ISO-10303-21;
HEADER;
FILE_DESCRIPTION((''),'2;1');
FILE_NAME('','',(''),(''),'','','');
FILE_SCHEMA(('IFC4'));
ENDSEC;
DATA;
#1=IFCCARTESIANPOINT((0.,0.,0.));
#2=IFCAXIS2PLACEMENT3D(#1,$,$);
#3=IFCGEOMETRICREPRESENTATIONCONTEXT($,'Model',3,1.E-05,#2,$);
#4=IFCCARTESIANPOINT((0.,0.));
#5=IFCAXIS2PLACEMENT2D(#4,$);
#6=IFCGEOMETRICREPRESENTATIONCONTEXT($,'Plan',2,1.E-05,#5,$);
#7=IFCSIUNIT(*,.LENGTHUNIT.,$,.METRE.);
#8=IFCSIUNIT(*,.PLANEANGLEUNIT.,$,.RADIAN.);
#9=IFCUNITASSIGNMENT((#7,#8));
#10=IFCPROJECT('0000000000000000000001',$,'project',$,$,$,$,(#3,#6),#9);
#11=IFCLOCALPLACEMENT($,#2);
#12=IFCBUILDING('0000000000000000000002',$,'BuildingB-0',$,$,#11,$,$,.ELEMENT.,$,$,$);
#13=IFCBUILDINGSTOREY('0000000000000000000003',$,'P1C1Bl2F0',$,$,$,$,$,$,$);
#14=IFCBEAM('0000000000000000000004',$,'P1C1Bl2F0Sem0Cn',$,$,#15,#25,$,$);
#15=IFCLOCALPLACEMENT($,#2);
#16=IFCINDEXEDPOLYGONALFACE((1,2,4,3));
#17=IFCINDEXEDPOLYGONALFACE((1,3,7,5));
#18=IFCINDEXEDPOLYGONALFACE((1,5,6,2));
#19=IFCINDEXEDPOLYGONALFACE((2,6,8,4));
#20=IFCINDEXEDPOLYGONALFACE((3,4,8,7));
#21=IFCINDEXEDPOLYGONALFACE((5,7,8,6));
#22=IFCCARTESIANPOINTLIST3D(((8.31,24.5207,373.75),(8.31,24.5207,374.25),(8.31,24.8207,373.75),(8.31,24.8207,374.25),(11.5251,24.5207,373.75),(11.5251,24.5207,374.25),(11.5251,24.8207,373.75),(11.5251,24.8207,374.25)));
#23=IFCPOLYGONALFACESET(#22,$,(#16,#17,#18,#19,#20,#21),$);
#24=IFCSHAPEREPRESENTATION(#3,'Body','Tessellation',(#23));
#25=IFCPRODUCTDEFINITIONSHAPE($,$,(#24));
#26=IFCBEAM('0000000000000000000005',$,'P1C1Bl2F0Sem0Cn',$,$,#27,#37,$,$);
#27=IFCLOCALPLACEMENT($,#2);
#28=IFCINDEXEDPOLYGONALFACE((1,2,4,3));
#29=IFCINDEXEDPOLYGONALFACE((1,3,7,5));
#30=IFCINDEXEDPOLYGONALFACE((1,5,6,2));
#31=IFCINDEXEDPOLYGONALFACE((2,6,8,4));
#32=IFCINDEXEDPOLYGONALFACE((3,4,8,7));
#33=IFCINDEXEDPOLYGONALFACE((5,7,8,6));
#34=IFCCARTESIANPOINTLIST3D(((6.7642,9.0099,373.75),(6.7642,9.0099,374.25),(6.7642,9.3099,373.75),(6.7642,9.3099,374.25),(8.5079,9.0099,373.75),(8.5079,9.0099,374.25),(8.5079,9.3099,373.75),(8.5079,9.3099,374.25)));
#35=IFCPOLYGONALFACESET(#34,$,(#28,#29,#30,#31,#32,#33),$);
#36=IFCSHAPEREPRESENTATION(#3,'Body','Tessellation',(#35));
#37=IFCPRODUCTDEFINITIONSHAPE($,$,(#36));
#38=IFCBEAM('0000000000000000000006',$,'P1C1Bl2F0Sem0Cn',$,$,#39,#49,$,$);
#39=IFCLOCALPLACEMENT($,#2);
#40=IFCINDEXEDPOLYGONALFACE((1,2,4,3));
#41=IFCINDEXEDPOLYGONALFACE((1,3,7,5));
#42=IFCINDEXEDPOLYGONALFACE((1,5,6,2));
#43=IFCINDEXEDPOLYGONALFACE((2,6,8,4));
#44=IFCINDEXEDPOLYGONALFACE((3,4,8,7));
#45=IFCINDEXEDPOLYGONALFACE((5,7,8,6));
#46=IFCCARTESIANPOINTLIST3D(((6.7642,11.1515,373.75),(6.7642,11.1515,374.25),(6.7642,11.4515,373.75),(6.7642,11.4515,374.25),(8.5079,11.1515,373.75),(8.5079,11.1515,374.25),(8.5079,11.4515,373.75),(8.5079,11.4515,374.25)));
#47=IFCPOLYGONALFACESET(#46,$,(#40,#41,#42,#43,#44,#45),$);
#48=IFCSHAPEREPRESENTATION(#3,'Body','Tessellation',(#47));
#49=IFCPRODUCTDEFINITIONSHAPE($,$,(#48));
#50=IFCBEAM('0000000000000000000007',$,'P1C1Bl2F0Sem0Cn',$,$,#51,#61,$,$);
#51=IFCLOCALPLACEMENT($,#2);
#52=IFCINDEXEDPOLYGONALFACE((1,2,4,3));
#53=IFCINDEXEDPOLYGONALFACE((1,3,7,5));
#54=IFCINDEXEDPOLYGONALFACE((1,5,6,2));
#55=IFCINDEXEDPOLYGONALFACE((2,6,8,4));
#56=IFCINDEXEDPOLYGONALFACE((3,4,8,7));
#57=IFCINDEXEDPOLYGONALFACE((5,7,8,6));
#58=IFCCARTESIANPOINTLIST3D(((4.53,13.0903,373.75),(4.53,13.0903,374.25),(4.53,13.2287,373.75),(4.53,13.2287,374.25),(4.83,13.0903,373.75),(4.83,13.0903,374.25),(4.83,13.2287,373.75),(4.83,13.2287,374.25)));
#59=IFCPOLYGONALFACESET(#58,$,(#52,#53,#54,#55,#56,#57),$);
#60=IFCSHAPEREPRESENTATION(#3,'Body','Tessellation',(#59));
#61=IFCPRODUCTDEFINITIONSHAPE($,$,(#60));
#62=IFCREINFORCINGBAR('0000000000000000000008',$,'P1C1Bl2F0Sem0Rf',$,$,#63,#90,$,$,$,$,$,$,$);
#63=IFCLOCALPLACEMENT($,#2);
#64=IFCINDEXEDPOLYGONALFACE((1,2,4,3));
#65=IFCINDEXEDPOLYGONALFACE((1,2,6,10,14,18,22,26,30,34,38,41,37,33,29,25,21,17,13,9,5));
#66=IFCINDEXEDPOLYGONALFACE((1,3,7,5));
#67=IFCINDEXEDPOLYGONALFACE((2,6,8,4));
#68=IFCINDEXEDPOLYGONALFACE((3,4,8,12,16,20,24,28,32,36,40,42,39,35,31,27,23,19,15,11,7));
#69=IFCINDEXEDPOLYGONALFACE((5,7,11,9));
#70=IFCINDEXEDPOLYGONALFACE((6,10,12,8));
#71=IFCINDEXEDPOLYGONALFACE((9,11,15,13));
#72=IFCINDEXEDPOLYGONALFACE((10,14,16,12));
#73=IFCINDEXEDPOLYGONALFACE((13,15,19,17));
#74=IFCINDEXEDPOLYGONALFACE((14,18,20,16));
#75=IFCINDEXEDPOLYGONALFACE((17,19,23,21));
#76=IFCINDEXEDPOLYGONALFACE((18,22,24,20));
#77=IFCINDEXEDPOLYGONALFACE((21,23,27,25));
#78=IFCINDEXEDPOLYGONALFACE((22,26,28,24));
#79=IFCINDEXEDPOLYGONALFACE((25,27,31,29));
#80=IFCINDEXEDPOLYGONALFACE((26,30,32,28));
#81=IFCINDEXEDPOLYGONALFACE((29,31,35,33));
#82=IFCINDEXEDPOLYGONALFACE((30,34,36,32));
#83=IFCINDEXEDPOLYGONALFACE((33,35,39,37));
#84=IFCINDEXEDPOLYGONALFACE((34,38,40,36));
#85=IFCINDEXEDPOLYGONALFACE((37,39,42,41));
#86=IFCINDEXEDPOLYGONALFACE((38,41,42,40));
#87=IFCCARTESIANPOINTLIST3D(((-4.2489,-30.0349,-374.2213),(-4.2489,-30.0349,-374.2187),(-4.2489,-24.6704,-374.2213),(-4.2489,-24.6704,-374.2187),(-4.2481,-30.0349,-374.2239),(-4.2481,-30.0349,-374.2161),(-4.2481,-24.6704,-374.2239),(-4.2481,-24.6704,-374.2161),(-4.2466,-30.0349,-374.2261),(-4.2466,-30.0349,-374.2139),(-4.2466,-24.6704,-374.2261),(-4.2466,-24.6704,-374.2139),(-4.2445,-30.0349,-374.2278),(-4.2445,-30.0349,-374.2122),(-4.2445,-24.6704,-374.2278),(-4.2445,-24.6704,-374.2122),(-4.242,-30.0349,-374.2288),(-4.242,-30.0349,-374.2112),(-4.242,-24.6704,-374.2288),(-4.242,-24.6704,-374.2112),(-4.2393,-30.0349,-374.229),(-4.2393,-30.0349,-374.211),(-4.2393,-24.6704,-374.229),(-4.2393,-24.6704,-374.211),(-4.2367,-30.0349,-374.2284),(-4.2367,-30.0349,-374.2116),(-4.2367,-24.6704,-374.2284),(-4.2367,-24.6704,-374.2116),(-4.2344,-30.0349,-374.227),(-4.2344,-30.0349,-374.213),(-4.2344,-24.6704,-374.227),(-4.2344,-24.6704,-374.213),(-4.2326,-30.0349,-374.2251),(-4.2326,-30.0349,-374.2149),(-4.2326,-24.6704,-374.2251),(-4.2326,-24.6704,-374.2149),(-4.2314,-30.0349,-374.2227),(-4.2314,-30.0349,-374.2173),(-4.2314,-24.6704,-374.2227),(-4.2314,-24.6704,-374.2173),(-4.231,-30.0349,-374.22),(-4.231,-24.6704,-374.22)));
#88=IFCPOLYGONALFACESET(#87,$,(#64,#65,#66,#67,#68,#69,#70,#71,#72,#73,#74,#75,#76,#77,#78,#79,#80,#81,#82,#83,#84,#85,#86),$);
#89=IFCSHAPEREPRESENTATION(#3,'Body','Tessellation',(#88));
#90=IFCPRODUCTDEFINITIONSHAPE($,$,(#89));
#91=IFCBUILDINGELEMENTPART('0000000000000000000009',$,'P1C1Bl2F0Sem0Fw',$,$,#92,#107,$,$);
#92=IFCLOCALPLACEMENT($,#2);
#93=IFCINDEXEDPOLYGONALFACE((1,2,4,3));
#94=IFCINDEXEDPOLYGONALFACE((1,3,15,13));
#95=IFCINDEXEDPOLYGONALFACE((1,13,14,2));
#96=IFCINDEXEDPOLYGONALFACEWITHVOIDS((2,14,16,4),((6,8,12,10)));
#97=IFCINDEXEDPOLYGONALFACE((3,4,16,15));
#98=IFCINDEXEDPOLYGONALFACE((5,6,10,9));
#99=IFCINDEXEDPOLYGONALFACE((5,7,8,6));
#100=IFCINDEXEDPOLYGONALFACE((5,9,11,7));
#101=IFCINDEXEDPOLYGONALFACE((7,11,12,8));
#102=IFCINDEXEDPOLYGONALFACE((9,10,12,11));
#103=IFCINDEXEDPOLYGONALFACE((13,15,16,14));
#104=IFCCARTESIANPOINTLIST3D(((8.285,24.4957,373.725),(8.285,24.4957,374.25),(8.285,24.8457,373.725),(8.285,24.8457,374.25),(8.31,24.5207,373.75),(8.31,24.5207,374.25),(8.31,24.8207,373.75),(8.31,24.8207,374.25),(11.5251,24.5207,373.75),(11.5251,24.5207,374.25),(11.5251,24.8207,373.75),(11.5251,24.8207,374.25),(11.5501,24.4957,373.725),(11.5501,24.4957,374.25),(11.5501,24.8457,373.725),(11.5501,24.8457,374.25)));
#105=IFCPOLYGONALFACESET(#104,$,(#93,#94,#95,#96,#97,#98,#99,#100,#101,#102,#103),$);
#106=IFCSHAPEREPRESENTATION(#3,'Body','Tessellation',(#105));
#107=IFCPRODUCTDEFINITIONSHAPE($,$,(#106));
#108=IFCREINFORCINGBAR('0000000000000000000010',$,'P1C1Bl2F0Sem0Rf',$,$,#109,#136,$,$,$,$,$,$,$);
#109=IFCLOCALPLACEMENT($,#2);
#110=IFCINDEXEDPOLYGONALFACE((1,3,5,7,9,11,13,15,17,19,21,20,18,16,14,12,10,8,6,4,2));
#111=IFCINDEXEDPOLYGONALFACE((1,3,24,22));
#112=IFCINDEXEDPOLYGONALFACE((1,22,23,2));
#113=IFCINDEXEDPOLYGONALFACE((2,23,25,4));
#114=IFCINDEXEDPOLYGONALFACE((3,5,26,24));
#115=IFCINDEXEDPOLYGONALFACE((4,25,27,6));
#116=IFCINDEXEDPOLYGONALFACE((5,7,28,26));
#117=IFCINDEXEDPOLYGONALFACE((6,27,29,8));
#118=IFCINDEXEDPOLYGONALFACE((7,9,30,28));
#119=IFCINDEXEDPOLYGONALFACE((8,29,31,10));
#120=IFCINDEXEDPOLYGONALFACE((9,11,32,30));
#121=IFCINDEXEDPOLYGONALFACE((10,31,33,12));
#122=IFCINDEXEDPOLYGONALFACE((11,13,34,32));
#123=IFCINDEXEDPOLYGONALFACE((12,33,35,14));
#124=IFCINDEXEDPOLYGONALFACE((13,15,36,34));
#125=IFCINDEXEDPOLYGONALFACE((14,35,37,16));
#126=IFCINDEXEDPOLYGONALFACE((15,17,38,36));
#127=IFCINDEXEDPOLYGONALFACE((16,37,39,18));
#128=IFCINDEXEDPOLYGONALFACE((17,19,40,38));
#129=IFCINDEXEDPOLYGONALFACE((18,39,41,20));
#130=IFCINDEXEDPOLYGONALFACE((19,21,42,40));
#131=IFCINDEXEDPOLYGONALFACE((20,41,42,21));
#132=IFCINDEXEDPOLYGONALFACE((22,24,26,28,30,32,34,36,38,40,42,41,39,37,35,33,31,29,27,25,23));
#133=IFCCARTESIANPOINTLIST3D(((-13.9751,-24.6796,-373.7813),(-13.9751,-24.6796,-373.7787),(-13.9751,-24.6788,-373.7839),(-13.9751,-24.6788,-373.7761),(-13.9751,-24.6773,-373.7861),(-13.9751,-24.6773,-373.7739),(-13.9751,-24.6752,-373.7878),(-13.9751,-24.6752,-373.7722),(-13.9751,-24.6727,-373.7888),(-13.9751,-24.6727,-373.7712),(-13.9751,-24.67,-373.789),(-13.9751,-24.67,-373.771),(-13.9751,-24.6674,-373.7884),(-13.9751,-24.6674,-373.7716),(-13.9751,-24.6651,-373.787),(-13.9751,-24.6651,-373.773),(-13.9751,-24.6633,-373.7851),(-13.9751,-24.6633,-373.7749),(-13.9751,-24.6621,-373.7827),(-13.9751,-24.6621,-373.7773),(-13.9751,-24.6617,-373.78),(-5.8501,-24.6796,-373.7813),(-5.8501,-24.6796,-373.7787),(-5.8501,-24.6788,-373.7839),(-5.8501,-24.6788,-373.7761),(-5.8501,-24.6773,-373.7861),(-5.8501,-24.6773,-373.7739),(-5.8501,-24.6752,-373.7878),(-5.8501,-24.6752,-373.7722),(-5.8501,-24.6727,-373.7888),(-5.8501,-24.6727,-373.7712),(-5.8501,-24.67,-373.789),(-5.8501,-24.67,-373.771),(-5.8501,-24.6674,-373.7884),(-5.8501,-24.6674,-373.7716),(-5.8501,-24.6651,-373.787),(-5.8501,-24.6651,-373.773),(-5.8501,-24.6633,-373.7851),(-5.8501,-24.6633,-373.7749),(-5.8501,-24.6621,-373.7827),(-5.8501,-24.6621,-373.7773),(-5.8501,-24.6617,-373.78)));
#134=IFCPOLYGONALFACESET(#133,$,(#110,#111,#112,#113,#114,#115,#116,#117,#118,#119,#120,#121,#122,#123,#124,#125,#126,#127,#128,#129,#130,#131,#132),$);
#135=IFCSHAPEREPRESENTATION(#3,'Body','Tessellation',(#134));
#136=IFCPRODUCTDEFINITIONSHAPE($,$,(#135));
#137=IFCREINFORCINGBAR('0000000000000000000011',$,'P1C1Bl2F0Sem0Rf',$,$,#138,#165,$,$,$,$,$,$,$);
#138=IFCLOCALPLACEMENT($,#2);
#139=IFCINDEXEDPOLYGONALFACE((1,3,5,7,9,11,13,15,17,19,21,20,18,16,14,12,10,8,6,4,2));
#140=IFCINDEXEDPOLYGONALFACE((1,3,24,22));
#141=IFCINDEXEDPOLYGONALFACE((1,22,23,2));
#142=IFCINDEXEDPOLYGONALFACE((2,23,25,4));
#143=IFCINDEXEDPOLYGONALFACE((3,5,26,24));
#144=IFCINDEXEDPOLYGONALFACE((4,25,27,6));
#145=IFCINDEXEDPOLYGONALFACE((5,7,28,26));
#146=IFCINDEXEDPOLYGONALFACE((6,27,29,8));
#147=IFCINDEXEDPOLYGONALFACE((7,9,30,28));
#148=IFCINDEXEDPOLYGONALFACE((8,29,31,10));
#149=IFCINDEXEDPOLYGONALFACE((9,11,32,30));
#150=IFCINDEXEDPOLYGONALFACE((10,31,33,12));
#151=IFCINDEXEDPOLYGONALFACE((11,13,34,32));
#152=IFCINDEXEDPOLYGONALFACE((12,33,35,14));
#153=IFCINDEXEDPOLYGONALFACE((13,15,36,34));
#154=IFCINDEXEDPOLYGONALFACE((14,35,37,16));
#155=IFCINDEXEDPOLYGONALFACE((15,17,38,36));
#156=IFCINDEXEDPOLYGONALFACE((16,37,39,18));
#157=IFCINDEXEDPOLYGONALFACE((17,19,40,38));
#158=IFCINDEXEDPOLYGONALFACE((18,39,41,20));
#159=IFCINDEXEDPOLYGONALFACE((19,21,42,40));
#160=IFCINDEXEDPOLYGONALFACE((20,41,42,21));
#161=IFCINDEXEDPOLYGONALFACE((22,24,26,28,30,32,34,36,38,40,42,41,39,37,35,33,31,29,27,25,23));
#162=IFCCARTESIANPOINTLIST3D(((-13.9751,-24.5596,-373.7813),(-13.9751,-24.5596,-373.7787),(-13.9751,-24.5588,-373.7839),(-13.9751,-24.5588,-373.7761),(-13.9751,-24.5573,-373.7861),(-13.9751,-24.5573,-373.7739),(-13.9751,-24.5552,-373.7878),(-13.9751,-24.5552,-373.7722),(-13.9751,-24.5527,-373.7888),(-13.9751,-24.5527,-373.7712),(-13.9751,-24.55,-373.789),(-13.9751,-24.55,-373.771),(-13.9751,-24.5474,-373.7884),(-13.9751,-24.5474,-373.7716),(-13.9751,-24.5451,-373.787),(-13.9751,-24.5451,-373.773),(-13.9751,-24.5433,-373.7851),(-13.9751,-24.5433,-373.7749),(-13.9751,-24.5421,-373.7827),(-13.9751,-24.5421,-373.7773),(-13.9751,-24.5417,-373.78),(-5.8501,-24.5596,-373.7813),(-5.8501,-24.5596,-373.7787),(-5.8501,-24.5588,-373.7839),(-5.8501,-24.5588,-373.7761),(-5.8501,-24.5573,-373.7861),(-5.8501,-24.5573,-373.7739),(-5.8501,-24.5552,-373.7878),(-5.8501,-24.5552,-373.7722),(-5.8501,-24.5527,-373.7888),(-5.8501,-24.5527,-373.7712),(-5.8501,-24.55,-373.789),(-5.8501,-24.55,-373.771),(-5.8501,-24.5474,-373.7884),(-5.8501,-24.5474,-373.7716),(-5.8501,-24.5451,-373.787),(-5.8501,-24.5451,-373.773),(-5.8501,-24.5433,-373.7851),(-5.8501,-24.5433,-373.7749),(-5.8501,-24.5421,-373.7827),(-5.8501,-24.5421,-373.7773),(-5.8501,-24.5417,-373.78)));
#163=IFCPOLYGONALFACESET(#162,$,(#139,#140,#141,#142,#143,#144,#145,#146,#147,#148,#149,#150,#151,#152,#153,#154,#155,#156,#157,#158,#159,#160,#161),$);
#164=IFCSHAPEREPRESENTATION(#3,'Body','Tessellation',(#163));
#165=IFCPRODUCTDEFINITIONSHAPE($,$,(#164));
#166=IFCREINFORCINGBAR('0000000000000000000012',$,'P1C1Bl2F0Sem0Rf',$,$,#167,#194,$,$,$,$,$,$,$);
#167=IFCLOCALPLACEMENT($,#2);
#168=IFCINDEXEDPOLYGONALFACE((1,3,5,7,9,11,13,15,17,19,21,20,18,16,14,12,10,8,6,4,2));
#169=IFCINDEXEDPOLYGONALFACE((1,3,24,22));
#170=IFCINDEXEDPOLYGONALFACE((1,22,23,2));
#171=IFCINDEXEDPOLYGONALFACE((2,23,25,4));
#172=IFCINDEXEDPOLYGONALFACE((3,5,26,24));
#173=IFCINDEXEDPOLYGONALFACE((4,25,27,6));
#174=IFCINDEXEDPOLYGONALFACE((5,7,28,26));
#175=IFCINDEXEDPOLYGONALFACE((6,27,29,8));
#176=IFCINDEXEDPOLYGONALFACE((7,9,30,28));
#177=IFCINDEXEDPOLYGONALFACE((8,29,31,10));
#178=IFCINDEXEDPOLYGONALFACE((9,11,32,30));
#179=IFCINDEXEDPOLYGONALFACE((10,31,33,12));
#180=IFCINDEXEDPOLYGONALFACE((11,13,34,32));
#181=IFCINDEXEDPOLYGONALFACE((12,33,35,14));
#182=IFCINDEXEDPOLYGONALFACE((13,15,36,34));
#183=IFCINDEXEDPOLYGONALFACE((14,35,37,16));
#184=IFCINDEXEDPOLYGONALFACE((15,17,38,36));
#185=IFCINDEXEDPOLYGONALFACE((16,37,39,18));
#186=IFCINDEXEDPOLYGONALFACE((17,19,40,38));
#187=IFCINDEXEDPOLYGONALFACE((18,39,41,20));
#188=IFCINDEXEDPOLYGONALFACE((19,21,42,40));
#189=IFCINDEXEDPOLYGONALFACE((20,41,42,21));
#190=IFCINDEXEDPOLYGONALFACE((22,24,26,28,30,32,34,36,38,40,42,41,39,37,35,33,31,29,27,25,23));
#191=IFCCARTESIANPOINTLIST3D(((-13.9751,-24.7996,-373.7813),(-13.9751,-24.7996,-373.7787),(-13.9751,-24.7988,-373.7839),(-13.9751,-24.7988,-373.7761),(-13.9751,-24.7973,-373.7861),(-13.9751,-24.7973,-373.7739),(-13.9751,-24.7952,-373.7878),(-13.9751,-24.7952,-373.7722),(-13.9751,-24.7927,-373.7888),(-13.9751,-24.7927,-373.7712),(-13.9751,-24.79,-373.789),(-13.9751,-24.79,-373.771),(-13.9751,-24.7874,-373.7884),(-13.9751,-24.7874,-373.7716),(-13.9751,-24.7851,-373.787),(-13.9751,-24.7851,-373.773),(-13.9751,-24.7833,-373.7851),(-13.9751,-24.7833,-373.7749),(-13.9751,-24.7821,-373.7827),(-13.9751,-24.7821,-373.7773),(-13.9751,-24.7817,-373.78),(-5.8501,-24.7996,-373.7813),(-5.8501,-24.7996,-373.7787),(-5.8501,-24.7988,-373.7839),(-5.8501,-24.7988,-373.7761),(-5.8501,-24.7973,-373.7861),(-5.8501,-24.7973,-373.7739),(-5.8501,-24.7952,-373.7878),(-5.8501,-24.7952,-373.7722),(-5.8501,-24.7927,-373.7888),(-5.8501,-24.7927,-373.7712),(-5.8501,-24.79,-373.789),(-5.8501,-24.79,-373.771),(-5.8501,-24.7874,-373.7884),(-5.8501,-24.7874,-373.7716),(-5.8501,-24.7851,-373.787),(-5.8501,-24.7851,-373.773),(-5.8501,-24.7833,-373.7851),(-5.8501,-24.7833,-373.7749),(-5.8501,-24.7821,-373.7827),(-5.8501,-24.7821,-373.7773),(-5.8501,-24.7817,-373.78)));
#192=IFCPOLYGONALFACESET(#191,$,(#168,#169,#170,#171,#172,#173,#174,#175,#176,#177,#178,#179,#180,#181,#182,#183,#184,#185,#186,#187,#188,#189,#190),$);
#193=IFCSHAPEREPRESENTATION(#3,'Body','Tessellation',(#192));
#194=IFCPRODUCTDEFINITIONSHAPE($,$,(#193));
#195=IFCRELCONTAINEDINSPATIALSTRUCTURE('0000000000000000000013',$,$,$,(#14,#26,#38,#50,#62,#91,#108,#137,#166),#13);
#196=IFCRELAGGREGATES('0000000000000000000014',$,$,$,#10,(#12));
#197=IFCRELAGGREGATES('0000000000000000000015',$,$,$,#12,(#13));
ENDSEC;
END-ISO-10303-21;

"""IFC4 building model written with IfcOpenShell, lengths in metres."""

from ifc_helpers import new_model, entity, si_unit, origin, origin_2d, place, context, project, spatial, polyline, outline, extrude, element, save


model = new_model("IFC4")

# Units and contexts
model_context = context("Model", 3, precision=1e-05, world=origin())
plan_context = context("Plan", 2, precision=1e-05, world=origin_2d())
ifc_project = project(units=[si_unit("LENGTHUNIT", "METRE"), si_unit("PLANEANGLEUNIT", "RADIAN")], contexts=[model_context, plan_context])

# Building, storey
building_placement = place(None, origin())
building = spatial("IfcBuilding", under=ifc_project, at=building_placement, Name="BuildingB-0", CompositionType="ELEMENT")
storey = spatial("IfcBuildingStorey", under=building, Name="P1C1Bl2F0")

# Beams
element("IfcBeam", 1, inside=storey, Name="P1C1Bl2F0Sem0Cn", context=model_context, shape_type="SweptSolid", body=[
    extrude(outline(polyline([(8.31, 24.5207, 373.75), (8.31, 24.8207, 373.75), (11.5251, 24.8207, 373.75), (11.5251, 24.5207, 373.75), (8.31, 24.5207, 373.75)])), None, (0.0, 0.0, 1.0), 0.5),
])
element("IfcBeam", 2, inside=storey, Name="P1C1Bl2F0Sem0Cn", context=model_context, shape_type="SweptSolid", body=[
    extrude(outline(polyline([(6.7642, 9.0099, 373.75), (6.7642, 9.3099, 373.75), (8.5079, 9.3099, 373.75), (8.5079, 9.0099, 373.75), (6.7642, 9.0099, 373.75)])), None, (0.0, 0.0, 1.0), 0.5),
])
element("IfcBeam", 3, inside=storey, Name="P1C1Bl2F0Sem0Cn", context=model_context, shape_type="SweptSolid", body=[
    extrude(outline(polyline([(6.7642, 11.1515, 373.75), (6.7642, 11.4515, 373.75), (8.5079, 11.4515, 373.75), (8.5079, 11.1515, 373.75), (6.7642, 11.1515, 373.75)])), None, (0.0, 0.0, 1.0), 0.5),
])
element("IfcBeam", 4, inside=storey, Name="P1C1Bl2F0Sem0Cn", context=model_context, shape_type="SweptSolid", body=[
    extrude(outline(polyline([(4.53, 13.0903, 373.75), (4.53, 13.2287, 373.75), (4.83, 13.2287, 373.75), (4.83, 13.0903, 373.75), (4.53, 13.0903, 373.75)])), None, (0.0, 0.0, 1.0), 0.5),
])

# Reinforcing bar
element("IfcReinforcingBar", 5, inside=storey, Name="P1C1Bl2F0Sem0Rf", context=model_context, shape_type="SweptSolid", body=[
    entity("IfcSurfaceCurveSweptAreaSolid", entity("IfcCircleProfileDef", "AREA", None, None, 0.009), None, entity("IfcPolyline", [entity("IfcCartesianPoint", [4.24, 24.6704, 374.22]), entity("IfcCartesianPoint", [4.24, 30.0349, 374.22])]), None, None, entity("IfcPlane", entity("IfcAxis2Placement3D", entity("IfcCartesianPoint", [4.24, 24.6704, 374.22]), entity("IfcDirection", [0.0, 0.0, 1.0]), entity("IfcDirection", [1.0, 0.0, 0.0])))),
])

# Building element part, opening
building_element_part_1 = element("IfcBuildingElementPart", 6, inside=storey, Name="P1C1Bl2F0Sem0Fw", context=model_context, shape_type="SweptSolid", body=[
    extrude(outline(polyline([(8.285, 24.4957, 373.725), (8.285, 24.8457, 373.725), (11.5501, 24.8457, 373.725), (11.5501, 24.4957, 373.725), (8.285, 24.4957, 373.725)])), None, (0.0, 0.0, 1.0), 0.525),
])
element("IfcOpeningElement", 7, inside=storey, cuts=building_element_part_1, context=model_context, shape_type="SweptSolid", body=[
    extrude(outline(polyline([(8.31, 24.5207, 373.75), (8.31, 24.8207, 373.75), (11.5251, 24.8207, 373.75), (11.5251, 24.5207, 373.75), (8.31, 24.5207, 373.75)])), None, (0.0, 0.0, 1.0), 0.5),
])

# Reinforcing bars
element("IfcReinforcingBar", 8, inside=storey, Name="P1C1Bl2F0Sem0Rf", context=model_context, shape_type="SweptSolid", body=[
    entity("IfcSurfaceCurveSweptAreaSolid", entity("IfcCircleProfileDef", "AREA", None, None, 0.009), None, entity("IfcPolyline", [entity("IfcCartesianPoint", [5.8501, 24.6707, 373.78]), entity("IfcCartesianPoint", [13.9751, 24.6707, 373.78])]), None, None, entity("IfcPlane", entity("IfcAxis2Placement3D", entity("IfcCartesianPoint", [5.8501, 24.6707, 373.78]), entity("IfcDirection", [0.0, 0.0, 1.0]), entity("IfcDirection", [1.0, 0.0, 0.0])))),
])
element("IfcReinforcingBar", 9, inside=storey, Name="P1C1Bl2F0Sem0Rf", context=model_context, shape_type="SweptSolid", body=[
    entity("IfcSurfaceCurveSweptAreaSolid", entity("IfcCircleProfileDef", "AREA", None, None, 0.009), None, entity("IfcPolyline", [entity("IfcCartesianPoint", [5.8501, 24.5507, 373.78]), entity("IfcCartesianPoint", [13.9751, 24.5507, 373.78])]), None, None, entity("IfcPlane", entity("IfcAxis2Placement3D", entity("IfcCartesianPoint", [5.8501, 24.5507, 373.78]), entity("IfcDirection", [0.0, 0.0, 1.0]), entity("IfcDirection", [1.0, 0.0, 0.0])))),
])
element("IfcReinforcingBar", 10, inside=storey, Name="P1C1Bl2F0Sem0Rf", context=model_context, shape_type="SweptSolid", body=[
    entity("IfcSurfaceCurveSweptAreaSolid", entity("IfcCircleProfileDef", "AREA", None, None, 0.009), None, entity("IfcPolyline", [entity("IfcCartesianPoint", [5.8501, 24.7907, 373.78]), entity("IfcCartesianPoint", [13.9751, 24.7907, 373.78])]), None, None, entity("IfcPlane", entity("IfcAxis2Placement3D", entity("IfcCartesianPoint", [5.8501, 24.7907, 373.78]), entity("IfcDirection", [0.0, 0.0, 1.0]), entity("IfcDirection", [1.0, 0.0, 0.0])))),
])

save(model, "model.ifc")
